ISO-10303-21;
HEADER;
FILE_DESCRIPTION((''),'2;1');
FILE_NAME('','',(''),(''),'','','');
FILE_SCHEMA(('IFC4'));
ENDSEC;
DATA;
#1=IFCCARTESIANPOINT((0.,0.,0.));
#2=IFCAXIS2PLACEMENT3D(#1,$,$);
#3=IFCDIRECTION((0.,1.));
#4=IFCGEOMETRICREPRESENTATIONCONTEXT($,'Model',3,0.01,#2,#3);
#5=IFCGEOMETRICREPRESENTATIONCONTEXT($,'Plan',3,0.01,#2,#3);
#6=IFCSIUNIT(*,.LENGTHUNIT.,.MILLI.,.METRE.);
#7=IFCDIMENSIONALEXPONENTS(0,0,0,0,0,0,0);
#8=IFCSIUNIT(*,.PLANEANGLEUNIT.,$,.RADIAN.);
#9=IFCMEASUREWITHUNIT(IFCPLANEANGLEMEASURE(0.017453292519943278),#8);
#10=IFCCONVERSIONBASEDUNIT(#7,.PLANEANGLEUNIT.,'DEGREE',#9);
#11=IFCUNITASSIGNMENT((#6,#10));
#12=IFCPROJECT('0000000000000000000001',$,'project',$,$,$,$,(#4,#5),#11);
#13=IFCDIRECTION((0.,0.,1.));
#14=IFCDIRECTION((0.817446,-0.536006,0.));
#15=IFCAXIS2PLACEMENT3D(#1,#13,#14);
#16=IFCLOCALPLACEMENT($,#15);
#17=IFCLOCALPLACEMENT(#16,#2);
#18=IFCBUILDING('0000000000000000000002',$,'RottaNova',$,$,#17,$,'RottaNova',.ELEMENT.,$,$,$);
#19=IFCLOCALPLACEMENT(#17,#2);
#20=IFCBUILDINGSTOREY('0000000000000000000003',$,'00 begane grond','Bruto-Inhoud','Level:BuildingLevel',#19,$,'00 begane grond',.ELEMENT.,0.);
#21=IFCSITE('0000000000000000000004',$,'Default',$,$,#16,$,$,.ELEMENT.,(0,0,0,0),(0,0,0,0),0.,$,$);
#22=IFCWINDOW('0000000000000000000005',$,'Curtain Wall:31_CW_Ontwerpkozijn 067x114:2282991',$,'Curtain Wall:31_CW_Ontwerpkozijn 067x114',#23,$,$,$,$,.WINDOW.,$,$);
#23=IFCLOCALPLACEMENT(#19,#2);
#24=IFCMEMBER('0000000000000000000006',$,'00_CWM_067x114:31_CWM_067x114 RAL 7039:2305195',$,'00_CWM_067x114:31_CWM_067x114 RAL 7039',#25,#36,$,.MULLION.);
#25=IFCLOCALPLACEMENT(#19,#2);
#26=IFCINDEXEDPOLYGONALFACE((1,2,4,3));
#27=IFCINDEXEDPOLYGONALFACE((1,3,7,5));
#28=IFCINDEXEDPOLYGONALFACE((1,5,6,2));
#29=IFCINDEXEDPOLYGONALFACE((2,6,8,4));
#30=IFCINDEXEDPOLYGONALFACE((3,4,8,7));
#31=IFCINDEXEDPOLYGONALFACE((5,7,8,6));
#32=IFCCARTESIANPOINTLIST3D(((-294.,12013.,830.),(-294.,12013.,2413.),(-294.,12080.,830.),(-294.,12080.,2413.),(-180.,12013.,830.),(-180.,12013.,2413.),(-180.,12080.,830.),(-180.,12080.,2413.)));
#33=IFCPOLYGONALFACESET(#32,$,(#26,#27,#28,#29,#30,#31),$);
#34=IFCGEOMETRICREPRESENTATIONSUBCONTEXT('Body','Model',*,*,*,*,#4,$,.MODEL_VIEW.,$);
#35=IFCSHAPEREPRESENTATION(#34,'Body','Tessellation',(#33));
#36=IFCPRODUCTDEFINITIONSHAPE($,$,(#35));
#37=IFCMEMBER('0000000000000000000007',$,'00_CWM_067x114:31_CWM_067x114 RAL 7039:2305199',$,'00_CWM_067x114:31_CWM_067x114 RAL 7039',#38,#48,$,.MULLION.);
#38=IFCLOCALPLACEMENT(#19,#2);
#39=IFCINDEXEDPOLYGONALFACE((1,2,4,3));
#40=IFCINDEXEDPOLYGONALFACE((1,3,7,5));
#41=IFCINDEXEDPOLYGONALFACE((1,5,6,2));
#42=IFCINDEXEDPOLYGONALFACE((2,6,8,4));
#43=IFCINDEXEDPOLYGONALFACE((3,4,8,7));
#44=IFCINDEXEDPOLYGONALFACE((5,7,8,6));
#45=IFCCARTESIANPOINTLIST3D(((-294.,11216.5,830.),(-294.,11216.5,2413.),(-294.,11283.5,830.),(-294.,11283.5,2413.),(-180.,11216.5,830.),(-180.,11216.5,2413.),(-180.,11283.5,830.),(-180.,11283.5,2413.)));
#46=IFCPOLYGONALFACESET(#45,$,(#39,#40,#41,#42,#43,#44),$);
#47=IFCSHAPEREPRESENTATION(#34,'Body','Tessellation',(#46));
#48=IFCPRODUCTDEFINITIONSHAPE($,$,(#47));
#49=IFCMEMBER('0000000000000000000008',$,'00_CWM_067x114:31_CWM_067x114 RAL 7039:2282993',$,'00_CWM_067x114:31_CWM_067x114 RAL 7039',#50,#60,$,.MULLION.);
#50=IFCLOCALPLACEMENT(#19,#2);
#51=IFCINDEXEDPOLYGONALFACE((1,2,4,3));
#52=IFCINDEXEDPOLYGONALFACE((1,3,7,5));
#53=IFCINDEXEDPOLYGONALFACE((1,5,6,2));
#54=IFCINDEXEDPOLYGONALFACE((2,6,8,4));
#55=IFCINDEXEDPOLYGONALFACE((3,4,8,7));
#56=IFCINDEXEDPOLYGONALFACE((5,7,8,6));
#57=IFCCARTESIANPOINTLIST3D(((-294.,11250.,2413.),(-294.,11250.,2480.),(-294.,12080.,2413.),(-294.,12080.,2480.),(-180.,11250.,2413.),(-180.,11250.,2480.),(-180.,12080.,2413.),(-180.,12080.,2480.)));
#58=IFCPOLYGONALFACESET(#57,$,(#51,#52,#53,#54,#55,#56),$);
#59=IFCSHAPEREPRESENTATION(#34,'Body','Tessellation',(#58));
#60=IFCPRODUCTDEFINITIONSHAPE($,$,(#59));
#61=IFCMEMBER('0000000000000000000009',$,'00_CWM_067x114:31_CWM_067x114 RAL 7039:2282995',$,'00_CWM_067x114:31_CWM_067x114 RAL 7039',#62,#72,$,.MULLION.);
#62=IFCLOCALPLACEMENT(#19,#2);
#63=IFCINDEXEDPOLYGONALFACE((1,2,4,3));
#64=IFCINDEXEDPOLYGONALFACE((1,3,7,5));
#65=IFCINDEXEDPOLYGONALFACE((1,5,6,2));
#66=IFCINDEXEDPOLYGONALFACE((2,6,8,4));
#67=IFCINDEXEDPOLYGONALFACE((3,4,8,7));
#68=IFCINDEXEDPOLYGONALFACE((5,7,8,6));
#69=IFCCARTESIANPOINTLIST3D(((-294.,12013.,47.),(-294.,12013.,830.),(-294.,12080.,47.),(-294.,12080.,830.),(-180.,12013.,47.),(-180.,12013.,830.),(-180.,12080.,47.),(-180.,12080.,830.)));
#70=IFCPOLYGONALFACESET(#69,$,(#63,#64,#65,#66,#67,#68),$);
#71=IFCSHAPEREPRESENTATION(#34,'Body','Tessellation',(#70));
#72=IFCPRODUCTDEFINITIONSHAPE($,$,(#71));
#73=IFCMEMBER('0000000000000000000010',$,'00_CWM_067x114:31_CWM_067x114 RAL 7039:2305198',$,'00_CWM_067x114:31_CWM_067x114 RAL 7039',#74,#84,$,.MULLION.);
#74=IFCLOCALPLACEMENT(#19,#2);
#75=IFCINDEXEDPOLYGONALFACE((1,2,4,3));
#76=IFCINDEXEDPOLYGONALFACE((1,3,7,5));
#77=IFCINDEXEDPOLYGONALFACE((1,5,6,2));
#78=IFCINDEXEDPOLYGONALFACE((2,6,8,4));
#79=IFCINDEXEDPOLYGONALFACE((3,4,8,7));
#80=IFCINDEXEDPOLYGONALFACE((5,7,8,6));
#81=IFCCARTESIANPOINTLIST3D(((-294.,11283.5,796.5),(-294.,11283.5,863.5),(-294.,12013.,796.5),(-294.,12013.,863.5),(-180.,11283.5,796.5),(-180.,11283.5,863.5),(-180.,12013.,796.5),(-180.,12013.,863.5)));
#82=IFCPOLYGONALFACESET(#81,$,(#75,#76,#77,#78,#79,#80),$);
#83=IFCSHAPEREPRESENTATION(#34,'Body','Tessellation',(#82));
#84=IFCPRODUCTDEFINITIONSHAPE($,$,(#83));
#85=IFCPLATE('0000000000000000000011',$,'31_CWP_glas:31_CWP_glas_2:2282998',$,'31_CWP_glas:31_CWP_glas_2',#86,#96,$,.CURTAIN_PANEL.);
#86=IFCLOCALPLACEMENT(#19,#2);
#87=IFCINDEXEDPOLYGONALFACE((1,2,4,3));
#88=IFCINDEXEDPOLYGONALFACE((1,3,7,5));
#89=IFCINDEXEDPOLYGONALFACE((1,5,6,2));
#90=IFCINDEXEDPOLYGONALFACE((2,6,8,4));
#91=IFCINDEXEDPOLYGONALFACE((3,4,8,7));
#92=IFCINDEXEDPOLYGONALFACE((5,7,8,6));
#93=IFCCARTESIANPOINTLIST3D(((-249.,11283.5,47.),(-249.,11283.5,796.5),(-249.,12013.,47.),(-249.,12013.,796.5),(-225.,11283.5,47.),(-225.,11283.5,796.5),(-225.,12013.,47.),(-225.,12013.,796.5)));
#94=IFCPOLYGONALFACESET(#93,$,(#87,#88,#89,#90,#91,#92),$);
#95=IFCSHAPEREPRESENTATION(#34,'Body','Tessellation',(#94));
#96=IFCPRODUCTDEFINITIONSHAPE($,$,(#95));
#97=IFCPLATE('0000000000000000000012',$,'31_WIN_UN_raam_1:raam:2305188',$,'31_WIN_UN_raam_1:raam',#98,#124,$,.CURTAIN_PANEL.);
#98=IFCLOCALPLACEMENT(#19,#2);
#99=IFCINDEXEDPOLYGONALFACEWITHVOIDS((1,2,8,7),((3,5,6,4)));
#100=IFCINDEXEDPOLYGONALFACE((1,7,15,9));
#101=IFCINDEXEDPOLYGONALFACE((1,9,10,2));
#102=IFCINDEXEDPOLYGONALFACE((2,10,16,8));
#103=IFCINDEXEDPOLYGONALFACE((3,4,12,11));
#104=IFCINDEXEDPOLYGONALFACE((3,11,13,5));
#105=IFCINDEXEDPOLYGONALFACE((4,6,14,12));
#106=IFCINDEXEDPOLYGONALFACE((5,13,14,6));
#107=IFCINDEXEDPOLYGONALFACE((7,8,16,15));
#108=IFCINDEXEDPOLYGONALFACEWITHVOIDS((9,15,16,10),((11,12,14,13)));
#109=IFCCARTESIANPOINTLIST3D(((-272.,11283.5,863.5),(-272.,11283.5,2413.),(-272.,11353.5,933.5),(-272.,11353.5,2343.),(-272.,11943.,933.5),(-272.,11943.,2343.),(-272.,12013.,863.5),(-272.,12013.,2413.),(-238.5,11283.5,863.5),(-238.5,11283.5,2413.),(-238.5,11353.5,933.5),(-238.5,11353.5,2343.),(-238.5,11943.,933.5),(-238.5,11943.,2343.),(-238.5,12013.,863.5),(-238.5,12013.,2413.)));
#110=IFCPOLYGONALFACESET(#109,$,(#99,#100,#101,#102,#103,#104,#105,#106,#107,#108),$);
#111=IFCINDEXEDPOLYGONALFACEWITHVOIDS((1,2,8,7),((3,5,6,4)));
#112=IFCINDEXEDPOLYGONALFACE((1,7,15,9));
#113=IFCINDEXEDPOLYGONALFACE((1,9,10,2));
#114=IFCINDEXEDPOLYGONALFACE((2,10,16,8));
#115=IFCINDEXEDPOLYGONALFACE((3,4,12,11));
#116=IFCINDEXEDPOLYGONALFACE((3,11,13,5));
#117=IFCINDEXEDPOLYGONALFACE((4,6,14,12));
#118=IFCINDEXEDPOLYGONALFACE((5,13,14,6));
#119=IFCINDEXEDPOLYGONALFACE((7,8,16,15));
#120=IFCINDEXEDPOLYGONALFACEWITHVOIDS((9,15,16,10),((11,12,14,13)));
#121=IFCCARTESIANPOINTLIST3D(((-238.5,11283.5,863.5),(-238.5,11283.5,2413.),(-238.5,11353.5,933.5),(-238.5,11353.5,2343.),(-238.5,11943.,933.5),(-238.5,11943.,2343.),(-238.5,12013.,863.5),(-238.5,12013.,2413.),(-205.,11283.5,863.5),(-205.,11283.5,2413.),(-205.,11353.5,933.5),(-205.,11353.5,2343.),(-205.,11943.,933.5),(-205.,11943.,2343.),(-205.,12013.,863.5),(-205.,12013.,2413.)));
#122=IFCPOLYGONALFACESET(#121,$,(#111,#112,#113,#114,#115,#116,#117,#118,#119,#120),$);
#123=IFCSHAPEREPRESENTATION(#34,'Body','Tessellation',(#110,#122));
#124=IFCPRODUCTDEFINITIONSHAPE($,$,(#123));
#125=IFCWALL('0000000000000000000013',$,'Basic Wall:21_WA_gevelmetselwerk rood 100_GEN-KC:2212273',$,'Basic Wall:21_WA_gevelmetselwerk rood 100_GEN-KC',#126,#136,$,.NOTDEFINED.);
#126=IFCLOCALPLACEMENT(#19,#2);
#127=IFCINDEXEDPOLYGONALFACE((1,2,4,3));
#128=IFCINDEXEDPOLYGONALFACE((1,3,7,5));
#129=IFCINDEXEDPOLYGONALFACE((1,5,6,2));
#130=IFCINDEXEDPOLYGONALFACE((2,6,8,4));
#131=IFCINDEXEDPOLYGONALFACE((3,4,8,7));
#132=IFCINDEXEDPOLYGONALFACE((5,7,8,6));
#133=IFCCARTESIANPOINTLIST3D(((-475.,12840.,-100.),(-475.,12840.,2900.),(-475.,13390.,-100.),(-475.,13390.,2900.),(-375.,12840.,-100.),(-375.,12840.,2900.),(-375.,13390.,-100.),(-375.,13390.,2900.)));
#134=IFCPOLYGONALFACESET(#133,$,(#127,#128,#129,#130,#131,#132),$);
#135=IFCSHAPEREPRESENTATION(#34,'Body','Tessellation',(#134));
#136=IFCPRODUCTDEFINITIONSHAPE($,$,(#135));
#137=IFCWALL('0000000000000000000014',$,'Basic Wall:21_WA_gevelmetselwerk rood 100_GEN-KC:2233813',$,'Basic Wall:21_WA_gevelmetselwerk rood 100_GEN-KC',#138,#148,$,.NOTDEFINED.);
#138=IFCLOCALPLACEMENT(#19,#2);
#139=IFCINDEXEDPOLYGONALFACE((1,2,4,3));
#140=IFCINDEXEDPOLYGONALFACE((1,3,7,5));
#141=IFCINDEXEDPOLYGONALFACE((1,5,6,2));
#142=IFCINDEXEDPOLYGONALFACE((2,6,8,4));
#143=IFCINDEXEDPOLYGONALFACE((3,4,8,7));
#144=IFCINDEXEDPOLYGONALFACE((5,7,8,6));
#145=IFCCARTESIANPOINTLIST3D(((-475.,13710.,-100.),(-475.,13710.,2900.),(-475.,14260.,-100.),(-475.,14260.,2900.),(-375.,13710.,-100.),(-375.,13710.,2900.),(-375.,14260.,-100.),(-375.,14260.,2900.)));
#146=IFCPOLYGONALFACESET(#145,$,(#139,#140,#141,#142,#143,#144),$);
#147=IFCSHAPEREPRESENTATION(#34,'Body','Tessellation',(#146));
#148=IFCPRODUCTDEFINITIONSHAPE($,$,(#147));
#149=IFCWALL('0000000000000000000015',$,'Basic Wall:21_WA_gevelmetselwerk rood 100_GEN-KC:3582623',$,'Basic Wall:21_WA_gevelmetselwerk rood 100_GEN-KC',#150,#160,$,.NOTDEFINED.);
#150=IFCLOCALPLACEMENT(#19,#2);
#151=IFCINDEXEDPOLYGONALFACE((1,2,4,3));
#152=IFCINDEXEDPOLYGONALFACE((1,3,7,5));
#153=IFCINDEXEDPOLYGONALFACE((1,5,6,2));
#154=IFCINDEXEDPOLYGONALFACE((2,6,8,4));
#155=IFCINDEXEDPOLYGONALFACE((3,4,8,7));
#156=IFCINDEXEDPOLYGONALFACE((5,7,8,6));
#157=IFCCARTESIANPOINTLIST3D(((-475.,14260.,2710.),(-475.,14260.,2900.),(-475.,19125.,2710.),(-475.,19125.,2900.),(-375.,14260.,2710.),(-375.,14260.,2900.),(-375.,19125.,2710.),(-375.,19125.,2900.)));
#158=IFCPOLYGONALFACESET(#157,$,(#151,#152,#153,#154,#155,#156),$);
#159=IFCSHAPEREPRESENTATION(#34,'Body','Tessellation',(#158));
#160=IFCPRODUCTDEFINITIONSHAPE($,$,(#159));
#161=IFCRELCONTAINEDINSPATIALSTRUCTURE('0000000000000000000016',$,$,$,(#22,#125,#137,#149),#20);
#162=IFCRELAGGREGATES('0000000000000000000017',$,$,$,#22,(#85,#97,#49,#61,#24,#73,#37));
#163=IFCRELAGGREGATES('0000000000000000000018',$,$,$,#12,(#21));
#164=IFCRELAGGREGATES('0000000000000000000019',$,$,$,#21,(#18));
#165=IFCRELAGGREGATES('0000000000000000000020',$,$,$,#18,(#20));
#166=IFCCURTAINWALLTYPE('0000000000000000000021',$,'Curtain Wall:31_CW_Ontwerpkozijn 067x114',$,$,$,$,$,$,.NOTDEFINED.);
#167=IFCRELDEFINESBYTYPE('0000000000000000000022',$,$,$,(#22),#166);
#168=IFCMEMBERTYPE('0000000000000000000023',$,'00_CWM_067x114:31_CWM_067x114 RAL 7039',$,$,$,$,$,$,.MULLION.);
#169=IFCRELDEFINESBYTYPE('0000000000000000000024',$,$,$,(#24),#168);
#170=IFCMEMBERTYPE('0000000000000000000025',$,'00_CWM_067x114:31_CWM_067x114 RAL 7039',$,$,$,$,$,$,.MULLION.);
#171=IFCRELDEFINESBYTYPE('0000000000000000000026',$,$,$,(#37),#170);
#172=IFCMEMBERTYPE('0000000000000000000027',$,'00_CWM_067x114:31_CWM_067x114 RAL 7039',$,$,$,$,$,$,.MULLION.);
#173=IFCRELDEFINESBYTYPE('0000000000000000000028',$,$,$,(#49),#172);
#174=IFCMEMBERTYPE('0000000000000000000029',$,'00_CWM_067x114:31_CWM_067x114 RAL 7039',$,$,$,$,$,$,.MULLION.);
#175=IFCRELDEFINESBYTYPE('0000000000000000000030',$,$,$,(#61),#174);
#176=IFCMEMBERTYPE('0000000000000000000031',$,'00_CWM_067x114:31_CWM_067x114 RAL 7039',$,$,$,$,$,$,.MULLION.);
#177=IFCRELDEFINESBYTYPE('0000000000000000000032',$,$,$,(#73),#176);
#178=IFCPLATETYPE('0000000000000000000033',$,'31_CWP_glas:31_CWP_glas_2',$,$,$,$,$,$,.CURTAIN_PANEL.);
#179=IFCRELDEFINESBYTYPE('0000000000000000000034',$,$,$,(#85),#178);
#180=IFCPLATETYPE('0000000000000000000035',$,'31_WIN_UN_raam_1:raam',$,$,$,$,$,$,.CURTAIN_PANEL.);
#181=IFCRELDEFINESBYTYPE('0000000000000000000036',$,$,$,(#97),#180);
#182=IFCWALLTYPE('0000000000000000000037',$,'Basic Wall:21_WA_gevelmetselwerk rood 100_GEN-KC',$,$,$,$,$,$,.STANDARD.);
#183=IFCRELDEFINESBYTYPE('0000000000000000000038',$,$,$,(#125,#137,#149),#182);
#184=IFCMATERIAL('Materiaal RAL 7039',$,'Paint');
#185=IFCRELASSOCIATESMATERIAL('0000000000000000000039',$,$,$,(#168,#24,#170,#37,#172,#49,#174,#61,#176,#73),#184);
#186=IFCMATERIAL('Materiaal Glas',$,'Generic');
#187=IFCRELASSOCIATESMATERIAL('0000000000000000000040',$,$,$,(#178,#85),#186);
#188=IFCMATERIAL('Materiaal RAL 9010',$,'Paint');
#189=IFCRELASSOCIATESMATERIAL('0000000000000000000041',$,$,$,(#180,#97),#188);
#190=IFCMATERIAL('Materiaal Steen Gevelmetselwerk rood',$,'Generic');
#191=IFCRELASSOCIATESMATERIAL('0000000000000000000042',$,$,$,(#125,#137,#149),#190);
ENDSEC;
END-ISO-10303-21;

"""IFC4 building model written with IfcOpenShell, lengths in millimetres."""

from ifc_helpers import new_model, entity, si_unit, converted_unit, direction, frame, origin, place, context, subcontext, project, spatial, indexed_curve, outline, extrude, source, transform, mapped, material, type_object, type_shapes, element, aggregate, save


model = new_model("IFC4")

# Units and contexts
model_context = context("Model", 3, precision=0.01, world=origin(), true_north=direction((0.0, 1.0)))
plan_context = context("Plan", 3, precision=0.01, world=origin(), true_north=direction((0.0, 1.0)))
body_context = subcontext(model_context, "Body", "Model", "MODEL_VIEW")
ifc_project = project(units=[si_unit("LENGTHUNIT", "METRE", prefix="MILLI"), converted_unit("PLANEANGLEUNIT", "DEGREE", entity("IfcPlaneAngleMeasure", 0.017453292519943278), si_unit("PLANEANGLEUNIT", "RADIAN"), dimensions=[0, 0, 0, 0, 0, 0, 0])], contexts=[model_context, plan_context])

# Site, building, storey
site_placement = place(None, frame((0.0, 0.0, 0.0), z_axis=(0.0, 0.0, 1.0), x_axis=(0.817446, -0.536006, 0.0)))
site = spatial("IfcSite", under=ifc_project, at=site_placement, Name="Default", CompositionType="ELEMENT", RefLatitude=(0, 0, 0, 0), RefLongitude=(0, 0, 0, 0), RefElevation=0.0)
building_placement = place(site_placement, origin())
building = spatial("IfcBuilding", under=site, at=building_placement, Name="RottaNova", LongName="RottaNova", CompositionType="ELEMENT")
storey_placement = place(building_placement, origin())
storey = spatial("IfcBuildingStorey", under=building, at=storey_placement, Name="00 begane grond", Description="Bruto-Inhoud", ObjectType="Level:BuildingLevel", LongName="00 begane grond", CompositionType="ELEMENT", Elevation=0.0)

# Window, members, plates
curtain_wall_type = type_object("IfcCurtainWallType", Name="Curtain Wall:31_CW_Ontwerpkozijn 067x114", PredefinedType="NOTDEFINED")
window_1_placement = place(storey_placement, origin())
window_1 = element("IfcWindow", 1, at=window_1_placement, inside=storey, type_object=curtain_wall_type, Name="Curtain Wall:31_CW_Ontwerpkozijn 067x114:2282991", ObjectType="Curtain Wall:31_CW_Ontwerpkozijn 067x114", PredefinedType="WINDOW")
ifc_material_1 = material(Name="Materiaal RAL 7039", Category="Paint")
member_type_1 = type_object("IfcMemberType", Name="00_CWM_067x114:31_CWM_067x114 RAL 7039", PredefinedType="MULLION", material=ifc_material_1)
shared_shape_1 = source(origin(), body_context, "Body", "SweptSolid", [
    extrude(outline(indexed_curve([(-33.5, -57.0), (33.5, -57.0), (33.5, 57.0), (-33.5, 57.0), (-33.5, -57.0)], self_intersect=False)), frame((-33.5, -57.0, -1583.0), z_axis=(0.0, 0.0, 1.0), x_axis=(-1.0, 0.0, 0.0)), (0.0, 0.0, 1.0), 1583.0),
])
type_shapes(member_type_1, [shared_shape_1])
member_1_placement = place(window_1_placement, frame((-180.0, 12080.0, 830.0), z_axis=(0.0, 0.0, -1.0), x_axis=(0.0, 1.0, 0.0)))
member_1 = element("IfcMember", 2, at=member_1_placement, type_object=member_type_1, material=ifc_material_1, Name="00_CWM_067x114:31_CWM_067x114 RAL 7039:2305195", ObjectType="00_CWM_067x114:31_CWM_067x114 RAL 7039", PredefinedType="MULLION", context=body_context, shape_type="MappedRepresentation", body=[
    mapped(shared_shape_1, transform((0.0, 0.0, 0.0), scale=1.0)),
])
member_type_2 = type_object("IfcMemberType", Name="00_CWM_067x114:31_CWM_067x114 RAL 7039", PredefinedType="MULLION", material=ifc_material_1)
shared_shape_2 = source(origin(), body_context, "Body", "SweptSolid", [
    extrude(outline(indexed_curve([(-33.5, -57.0), (33.5, -57.0), (33.5, 57.0), (-33.5, 57.0), (-33.5, -57.0)], self_intersect=False)), frame((0.0, -57.0, -1583.0), z_axis=(0.0, 0.0, 1.0), x_axis=(-1.0, 0.0, 0.0)), (0.0, 0.0, 1.0), 1583.0),
])
type_shapes(member_type_2, [shared_shape_2])
member_2_placement = place(window_1_placement, frame((-180.0, 11250.0, 830.0), z_axis=(0.0, 0.0, -1.0), x_axis=(0.0, 1.0, 0.0)))
member_2 = element("IfcMember", 3, at=member_2_placement, type_object=member_type_2, material=ifc_material_1, Name="00_CWM_067x114:31_CWM_067x114 RAL 7039:2305199", ObjectType="00_CWM_067x114:31_CWM_067x114 RAL 7039", PredefinedType="MULLION", context=body_context, shape_type="MappedRepresentation", body=[
    mapped(shared_shape_2, transform((0.0, 0.0, 0.0), scale=1.0)),
])
member_type_3 = type_object("IfcMemberType", Name="00_CWM_067x114:31_CWM_067x114 RAL 7039", PredefinedType="MULLION", material=ifc_material_1)
shared_shape_3 = source(origin(), body_context, "Body", "SweptSolid", [
    extrude(outline(indexed_curve([(-33.5, -57.0), (33.5, -57.0), (33.5, 57.0), (-33.5, 57.0), (-33.5, -57.0)], self_intersect=False)), frame((-33.5, -57.0, -830.0), z_axis=(0.0, 0.0, 1.0), x_axis=(-1.0, 0.0, 0.0)), (0.0, 0.0, 1.0), 830.0),
])
type_shapes(member_type_3, [shared_shape_3])
member_3_placement = place(window_1_placement, frame((-180.0, 12080.0, 2480.0), z_axis=(0.0, 1.0, 0.0), x_axis=(0.0, 0.0, 1.0)))
member_3 = element("IfcMember", 4, at=member_3_placement, type_object=member_type_3, material=ifc_material_1, Name="00_CWM_067x114:31_CWM_067x114 RAL 7039:2282993", ObjectType="00_CWM_067x114:31_CWM_067x114 RAL 7039", PredefinedType="MULLION", context=body_context, shape_type="MappedRepresentation", body=[
    mapped(shared_shape_3, transform((0.0, 0.0, 0.0), scale=1.0)),
])
member_type_4 = type_object("IfcMemberType", Name="00_CWM_067x114:31_CWM_067x114 RAL 7039", PredefinedType="MULLION", material=ifc_material_1)
shared_shape_4 = source(origin(), body_context, "Body", "SweptSolid", [
    extrude(outline(indexed_curve([(-33.5, -57.0), (33.5, -57.0), (33.5, 57.0), (-33.5, 57.0), (-33.5, -57.0)], self_intersect=False)), frame((-33.5, -57.0, -783.0), z_axis=(0.0, 0.0, 1.0), x_axis=(-1.0, 0.0, 0.0)), (0.0, 0.0, 1.0), 783.0),
])
type_shapes(member_type_4, [shared_shape_4])
member_4_placement = place(window_1_placement, frame((-180.0, 12080.0, 47.0), z_axis=(0.0, 0.0, -1.0), x_axis=(0.0, 1.0, 0.0)))
member_4 = element("IfcMember", 5, at=member_4_placement, type_object=member_type_4, material=ifc_material_1, Name="00_CWM_067x114:31_CWM_067x114 RAL 7039:2282995", ObjectType="00_CWM_067x114:31_CWM_067x114 RAL 7039", PredefinedType="MULLION", context=body_context, shape_type="MappedRepresentation", body=[
    mapped(shared_shape_4, transform((0.0, 0.0, 0.0), scale=1.0)),
])
member_type_5 = type_object("IfcMemberType", Name="00_CWM_067x114:31_CWM_067x114 RAL 7039", PredefinedType="MULLION", material=ifc_material_1)
shared_shape_5 = source(origin(), body_context, "Body", "SweptSolid", [
    extrude(outline(indexed_curve([(-33.5, -57.0), (33.5, -57.0), (33.5, 57.0), (-33.5, 57.0), (-33.5, -57.0)], self_intersect=False)), frame((0.0, -57.0, -729.5), z_axis=(0.0, 0.0, 1.0), x_axis=(-1.0, 0.0, 0.0)), (0.0, 0.0, 1.0), 729.5),
])
type_shapes(member_type_5, [shared_shape_5])
member_5_placement = place(window_1_placement, frame((-180.0, 12013.0, 830.0), z_axis=(0.0, 1.0, 0.0), x_axis=(0.0, 0.0, 1.0)))
member_5 = element("IfcMember", 6, at=member_5_placement, type_object=member_type_5, material=ifc_material_1, Name="00_CWM_067x114:31_CWM_067x114 RAL 7039:2305198", ObjectType="00_CWM_067x114:31_CWM_067x114 RAL 7039", PredefinedType="MULLION", context=body_context, shape_type="MappedRepresentation", body=[
    mapped(shared_shape_5, transform((0.0, 0.0, 0.0), scale=1.0)),
])
ifc_material_2 = material(Name="Materiaal Glas", Category="Generic")
plate_type_1 = type_object("IfcPlateType", Name="31_CWP_glas:31_CWP_glas_2", PredefinedType="CURTAIN_PANEL", material=ifc_material_2)
shared_shape_6 = source(origin(), body_context, "Body", "SweptSolid", [
    extrude(outline(indexed_curve([(-12.0, -364.7), (12.0, -364.7), (12.0, 364.7), (-12.0, 364.7), (-12.0, -364.7)], self_intersect=False)), frame((0.0, 57.0, 0.0), z_axis=(0.0, 0.0, 1.0), x_axis=(0.0, 1.0, 0.0)), (0.0, 0.0, 1.0), 749.5),
])
type_shapes(plate_type_1, [shared_shape_6])
plate_1_placement = place(window_1_placement, frame((-180.0, 11648.2, 47.0), z_axis=(0.0, 0.0, 1.0), x_axis=(0.0, 1.0, 0.0)))
plate_1 = element("IfcPlate", 7, at=plate_1_placement, type_object=plate_type_1, material=ifc_material_2, Name="31_CWP_glas:31_CWP_glas_2:2282998", ObjectType="31_CWP_glas:31_CWP_glas_2", PredefinedType="CURTAIN_PANEL", context=body_context, shape_type="MappedRepresentation", body=[
    mapped(shared_shape_6, transform((0.0, 0.0, 0.0), scale=1.0)),
])
ifc_material_3 = material(Name="Materiaal RAL 9010", Category="Paint")
plate_type_2 = type_object("IfcPlateType", Name="31_WIN_UN_raam_1:raam", PredefinedType="CURTAIN_PANEL", material=ifc_material_3)
shared_shape_7 = source(origin(), body_context, "Body", "SweptSolid", [
    extrude(outline(indexed_curve([(-364.7, -774.7), (364.7, -774.7), (364.7, 774.7), (-364.7, 774.7), (-364.7, -774.7)], self_intersect=False), holes=[indexed_curve([(-294.7, 704.7), (294.7, 704.7), (294.7, -704.8), (-294.7, -704.8), (-294.7, 704.7)], self_intersect=False)]), frame((0.0, 58.5, 774.8), z_axis=(0.0, 1.0, 0.0), x_axis=(1.0, 0.0, 0.0)), (0.0, 0.0, 1.0), 33.5),
    extrude(outline(indexed_curve([(-364.7, -774.7), (364.7, -774.7), (364.7, 774.7), (-364.7, 774.7), (-364.7, -774.7)], self_intersect=False), holes=[indexed_curve([(-294.7, 704.7), (294.7, 704.7), (294.7, -704.8), (-294.7, -704.8), (-294.7, 704.7)], self_intersect=False)]), frame((0.0, 25.0, 774.8), z_axis=(0.0, 1.0, 0.0), x_axis=(1.0, 0.0, 0.0)), (0.0, 0.0, 1.0), 33.5),
])
type_shapes(plate_type_2, [shared_shape_7])
plate_2_placement = place(window_1_placement, frame((-180.0, 11648.2, 863.5), z_axis=(0.0, 0.0, 1.0), x_axis=(0.0, 1.0, 0.0)))
plate_2 = element("IfcPlate", 8, at=plate_2_placement, type_object=plate_type_2, material=ifc_material_3, Name="31_WIN_UN_raam_1:raam:2305188", ObjectType="31_WIN_UN_raam_1:raam", PredefinedType="CURTAIN_PANEL", context=body_context, shape_type="MappedRepresentation", body=[
    mapped(shared_shape_7, transform((0.0, 0.0, 0.0), scale=1.0)),
])
aggregate(window_1, [plate_1, plate_2, member_3, member_4, member_1, member_5, member_2])

# Walls
ifc_material_4 = material(Name="Materiaal Steen Gevelmetselwerk rood", Category="Generic")
wall_type_1 = type_object("IfcWallType", Name="Basic Wall:21_WA_gevelmetselwerk rood 100_GEN-KC", PredefinedType="STANDARD")
wall_1_placement = place(storey_placement, frame((-425.0, 12840.0, -100.0), z_axis=(0.0, 0.0, 1.0), x_axis=(0.0, 1.0, 0.0)))
element("IfcWall", 9, at=wall_1_placement, inside=storey, type_object=wall_type_1, material=ifc_material_4, Name="Basic Wall:21_WA_gevelmetselwerk rood 100_GEN-KC:2212273", ObjectType="Basic Wall:21_WA_gevelmetselwerk rood 100_GEN-KC", PredefinedType="NOTDEFINED", context=body_context, shape_type="SweptSolid", body=[
    extrude(outline(indexed_curve([(550.0, 50.0), (0.0, 50.0), (0.0, -50.0), (550.0, -50.0), (550.0, 50.0)], self_intersect=False)), origin(), (0.0, 0.0, 1.0), 3000.0),
])
wall_2_placement = place(storey_placement, frame((-425.0, 13710.0, -100.0), z_axis=(0.0, 0.0, 1.0), x_axis=(0.0, 1.0, 0.0)))
element("IfcWall", 10, at=wall_2_placement, inside=storey, type_object=wall_type_1, material=ifc_material_4, Name="Basic Wall:21_WA_gevelmetselwerk rood 100_GEN-KC:2233813", ObjectType="Basic Wall:21_WA_gevelmetselwerk rood 100_GEN-KC", PredefinedType="NOTDEFINED", context=body_context, shape_type="SweptSolid", body=[
    extrude(outline(indexed_curve([(550.0, 50.0), (0.0, 50.0), (0.0, -50.0), (550.0, -50.0), (550.0, 50.0)], self_intersect=False)), origin(), (0.0, 0.0, 1.0), 3000.0),
])
wall_3_placement = place(storey_placement, frame((-425.0, 14260.0, 2710.0), z_axis=(0.0, 0.0, 1.0), x_axis=(0.0, 1.0, 0.0)))
element("IfcWall", 11, at=wall_3_placement, inside=storey, type_object=wall_type_1, material=ifc_material_4, Name="Basic Wall:21_WA_gevelmetselwerk rood 100_GEN-KC:3582623", ObjectType="Basic Wall:21_WA_gevelmetselwerk rood 100_GEN-KC", PredefinedType="NOTDEFINED", context=body_context, shape_type="SweptSolid", body=[
    extrude(outline(indexed_curve([(4865.0, 50.0), (0.0, 50.0), (0.0, -50.0), (4865.0, -50.0), (4865.0, 50.0)], self_intersect=False)), origin(), (0.0, 0.0, 1.0), 190.0),
])

save(model, "model.ifc")
